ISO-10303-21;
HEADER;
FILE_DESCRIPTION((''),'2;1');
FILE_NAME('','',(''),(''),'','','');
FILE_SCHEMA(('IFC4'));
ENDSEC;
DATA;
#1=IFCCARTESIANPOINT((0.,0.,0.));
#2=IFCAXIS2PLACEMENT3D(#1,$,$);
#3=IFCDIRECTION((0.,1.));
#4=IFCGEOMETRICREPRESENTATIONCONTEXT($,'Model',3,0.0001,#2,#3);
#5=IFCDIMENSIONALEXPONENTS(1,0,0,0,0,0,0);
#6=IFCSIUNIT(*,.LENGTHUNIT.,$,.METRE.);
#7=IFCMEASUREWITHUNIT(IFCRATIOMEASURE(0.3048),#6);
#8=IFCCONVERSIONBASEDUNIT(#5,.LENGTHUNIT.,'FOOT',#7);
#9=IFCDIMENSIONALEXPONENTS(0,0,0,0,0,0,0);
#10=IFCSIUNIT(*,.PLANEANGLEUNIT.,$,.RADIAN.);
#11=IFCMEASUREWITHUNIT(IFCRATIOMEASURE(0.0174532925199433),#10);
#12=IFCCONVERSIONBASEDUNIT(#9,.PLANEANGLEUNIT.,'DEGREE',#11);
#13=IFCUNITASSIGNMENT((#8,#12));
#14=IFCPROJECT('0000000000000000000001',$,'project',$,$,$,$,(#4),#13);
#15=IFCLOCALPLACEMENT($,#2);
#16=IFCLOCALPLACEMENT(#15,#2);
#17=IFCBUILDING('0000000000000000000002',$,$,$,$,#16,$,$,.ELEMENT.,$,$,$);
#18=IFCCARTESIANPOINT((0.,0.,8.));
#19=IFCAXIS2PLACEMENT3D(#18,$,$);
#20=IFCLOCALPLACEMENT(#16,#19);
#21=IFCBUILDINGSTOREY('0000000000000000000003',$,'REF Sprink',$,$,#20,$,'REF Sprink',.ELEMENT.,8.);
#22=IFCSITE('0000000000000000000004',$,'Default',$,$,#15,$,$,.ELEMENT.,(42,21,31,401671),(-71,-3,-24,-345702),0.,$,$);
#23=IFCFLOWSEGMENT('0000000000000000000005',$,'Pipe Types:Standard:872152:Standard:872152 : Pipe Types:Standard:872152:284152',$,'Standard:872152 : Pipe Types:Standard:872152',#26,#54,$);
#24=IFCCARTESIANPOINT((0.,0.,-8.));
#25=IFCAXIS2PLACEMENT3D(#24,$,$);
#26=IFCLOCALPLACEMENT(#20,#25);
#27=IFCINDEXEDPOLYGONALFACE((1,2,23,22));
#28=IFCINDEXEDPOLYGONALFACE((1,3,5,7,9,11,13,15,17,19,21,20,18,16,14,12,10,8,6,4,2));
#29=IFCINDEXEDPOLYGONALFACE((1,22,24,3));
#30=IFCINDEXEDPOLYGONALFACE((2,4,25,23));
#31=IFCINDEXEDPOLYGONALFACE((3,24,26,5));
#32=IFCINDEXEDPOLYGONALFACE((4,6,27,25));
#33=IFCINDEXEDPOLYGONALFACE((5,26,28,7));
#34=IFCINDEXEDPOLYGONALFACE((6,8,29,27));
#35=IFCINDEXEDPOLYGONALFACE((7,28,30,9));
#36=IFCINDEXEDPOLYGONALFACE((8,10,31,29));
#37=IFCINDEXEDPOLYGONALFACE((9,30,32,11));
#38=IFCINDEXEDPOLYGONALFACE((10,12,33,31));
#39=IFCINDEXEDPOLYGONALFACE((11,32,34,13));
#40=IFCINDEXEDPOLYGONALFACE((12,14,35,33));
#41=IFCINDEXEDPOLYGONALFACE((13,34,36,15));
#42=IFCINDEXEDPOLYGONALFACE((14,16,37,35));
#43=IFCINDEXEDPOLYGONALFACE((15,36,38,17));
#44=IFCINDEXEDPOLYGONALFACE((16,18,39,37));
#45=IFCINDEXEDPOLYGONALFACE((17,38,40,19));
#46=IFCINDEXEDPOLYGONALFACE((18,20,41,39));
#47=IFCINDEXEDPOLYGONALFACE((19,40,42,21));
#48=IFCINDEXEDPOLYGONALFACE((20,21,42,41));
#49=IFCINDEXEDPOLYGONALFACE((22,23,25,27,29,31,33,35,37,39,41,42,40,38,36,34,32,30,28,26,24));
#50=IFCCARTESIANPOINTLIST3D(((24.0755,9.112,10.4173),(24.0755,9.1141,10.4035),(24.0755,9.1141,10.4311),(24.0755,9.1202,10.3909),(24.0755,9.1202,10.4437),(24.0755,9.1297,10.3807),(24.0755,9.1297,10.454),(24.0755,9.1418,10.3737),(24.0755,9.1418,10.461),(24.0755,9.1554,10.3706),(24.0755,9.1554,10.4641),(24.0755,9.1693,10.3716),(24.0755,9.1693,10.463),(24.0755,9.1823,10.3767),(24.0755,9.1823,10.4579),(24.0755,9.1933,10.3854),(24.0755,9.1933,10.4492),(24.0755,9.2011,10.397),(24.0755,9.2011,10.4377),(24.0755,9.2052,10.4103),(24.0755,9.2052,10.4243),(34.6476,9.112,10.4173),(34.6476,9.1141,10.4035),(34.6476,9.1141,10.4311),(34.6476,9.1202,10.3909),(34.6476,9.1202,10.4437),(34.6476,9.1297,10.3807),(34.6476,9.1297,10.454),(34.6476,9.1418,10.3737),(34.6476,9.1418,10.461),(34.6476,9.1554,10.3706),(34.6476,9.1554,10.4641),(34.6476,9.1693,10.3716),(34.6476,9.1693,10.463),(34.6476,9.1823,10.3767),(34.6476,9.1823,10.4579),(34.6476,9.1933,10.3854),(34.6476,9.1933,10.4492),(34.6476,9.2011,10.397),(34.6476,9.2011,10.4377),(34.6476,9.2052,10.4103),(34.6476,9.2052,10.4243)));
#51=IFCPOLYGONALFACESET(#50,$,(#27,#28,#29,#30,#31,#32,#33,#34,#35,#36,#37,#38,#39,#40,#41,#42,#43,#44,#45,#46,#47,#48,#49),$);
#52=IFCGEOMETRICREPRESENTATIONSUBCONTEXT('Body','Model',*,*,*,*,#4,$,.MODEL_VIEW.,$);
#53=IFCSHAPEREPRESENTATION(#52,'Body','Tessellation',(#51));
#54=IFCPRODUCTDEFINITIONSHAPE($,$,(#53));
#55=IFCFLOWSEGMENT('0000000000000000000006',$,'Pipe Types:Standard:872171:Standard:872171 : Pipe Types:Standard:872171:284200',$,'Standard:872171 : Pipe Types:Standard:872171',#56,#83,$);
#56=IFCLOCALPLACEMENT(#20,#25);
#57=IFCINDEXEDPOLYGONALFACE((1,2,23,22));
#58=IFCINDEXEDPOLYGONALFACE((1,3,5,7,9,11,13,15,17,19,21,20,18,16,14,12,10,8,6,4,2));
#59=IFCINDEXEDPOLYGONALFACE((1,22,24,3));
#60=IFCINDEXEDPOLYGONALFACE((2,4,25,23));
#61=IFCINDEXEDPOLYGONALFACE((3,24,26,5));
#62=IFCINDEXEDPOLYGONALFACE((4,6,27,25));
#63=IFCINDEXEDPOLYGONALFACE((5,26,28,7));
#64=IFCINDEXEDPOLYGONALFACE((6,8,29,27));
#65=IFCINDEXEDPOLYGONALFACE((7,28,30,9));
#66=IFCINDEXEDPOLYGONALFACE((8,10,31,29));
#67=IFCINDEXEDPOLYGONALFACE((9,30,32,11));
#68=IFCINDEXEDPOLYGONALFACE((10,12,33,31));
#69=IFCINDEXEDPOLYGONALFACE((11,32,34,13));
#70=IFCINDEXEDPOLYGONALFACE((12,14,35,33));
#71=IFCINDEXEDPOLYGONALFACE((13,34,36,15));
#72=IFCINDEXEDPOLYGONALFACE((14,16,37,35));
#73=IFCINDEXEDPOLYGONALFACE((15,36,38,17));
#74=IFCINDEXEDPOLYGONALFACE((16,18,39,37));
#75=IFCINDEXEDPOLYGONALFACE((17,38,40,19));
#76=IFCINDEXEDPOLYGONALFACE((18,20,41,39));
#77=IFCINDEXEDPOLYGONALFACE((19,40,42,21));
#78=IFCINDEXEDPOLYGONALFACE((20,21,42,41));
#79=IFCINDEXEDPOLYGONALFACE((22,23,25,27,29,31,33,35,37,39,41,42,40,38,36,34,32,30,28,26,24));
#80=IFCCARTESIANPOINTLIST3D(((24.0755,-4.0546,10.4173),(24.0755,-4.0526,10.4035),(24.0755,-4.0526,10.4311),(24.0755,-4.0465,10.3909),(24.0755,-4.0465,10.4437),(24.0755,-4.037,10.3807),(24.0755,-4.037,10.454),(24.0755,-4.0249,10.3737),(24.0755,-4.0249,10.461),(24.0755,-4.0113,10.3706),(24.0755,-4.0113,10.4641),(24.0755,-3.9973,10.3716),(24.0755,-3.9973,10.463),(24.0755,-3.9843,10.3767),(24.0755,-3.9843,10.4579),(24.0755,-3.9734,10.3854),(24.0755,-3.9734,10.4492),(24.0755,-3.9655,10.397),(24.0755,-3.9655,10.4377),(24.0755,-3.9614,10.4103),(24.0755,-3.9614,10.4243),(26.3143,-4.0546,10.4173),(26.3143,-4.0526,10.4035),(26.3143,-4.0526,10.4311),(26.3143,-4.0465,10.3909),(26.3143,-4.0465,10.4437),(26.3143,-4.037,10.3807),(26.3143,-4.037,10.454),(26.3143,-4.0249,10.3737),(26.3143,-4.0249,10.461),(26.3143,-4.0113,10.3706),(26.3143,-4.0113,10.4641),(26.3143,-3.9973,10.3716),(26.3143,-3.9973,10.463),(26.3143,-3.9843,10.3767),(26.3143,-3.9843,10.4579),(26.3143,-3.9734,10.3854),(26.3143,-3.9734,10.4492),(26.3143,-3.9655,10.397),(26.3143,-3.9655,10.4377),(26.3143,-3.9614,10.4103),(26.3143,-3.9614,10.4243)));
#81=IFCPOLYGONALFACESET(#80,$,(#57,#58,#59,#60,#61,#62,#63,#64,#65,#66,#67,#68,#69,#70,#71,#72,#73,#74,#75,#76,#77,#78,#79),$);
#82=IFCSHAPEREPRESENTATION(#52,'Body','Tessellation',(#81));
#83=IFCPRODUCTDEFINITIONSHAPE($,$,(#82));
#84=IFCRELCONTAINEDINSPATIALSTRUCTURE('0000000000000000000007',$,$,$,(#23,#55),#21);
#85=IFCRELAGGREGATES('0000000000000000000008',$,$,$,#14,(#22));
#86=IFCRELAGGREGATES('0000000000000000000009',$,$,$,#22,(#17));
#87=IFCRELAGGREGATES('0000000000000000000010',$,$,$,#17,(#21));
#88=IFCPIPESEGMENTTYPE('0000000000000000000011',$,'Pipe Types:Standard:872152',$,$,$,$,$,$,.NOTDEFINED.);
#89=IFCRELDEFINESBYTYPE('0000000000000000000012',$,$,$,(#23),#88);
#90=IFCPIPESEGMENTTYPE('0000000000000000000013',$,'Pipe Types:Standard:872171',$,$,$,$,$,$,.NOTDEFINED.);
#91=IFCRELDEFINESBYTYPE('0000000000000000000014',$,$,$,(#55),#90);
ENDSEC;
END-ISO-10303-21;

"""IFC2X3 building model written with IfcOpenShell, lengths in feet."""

from ifc_helpers import new_model, entity, si_unit, converted_unit, direction, frame, origin, origin_2d_with_axis, place, context, subcontext, project, spatial, circle, extrude, source, transform, mapped, type_object, type_shapes, element, save


model = new_model("IFC2X3")

# Units and contexts
model_context = context("Model", 3, precision=0.0001, world=origin(), true_north=direction((0.0, 1.0)))
body_context = subcontext(model_context, "Body", "Model", "MODEL_VIEW")
ifc_project = project(units=[converted_unit("LENGTHUNIT", "FOOT", entity("IfcRatioMeasure", 0.3048), si_unit("LENGTHUNIT", "METRE"), dimensions=[1, 0, 0, 0, 0, 0, 0]), converted_unit("PLANEANGLEUNIT", "DEGREE", entity("IfcRatioMeasure", 0.0174532925199433), si_unit("PLANEANGLEUNIT", "RADIAN"), dimensions=[0, 0, 0, 0, 0, 0, 0])], contexts=[model_context])

# Site, building, storey
site_placement = place(None, origin())
site = spatial("IfcSite", under=ifc_project, at=site_placement, Name="Default", CompositionType="ELEMENT", RefLatitude=(42, 21, 31, 401671), RefLongitude=(-71, -3, -24, -345702), RefElevation=0.0)
building_placement = place(site_placement, origin())
building = spatial("IfcBuilding", under=site, at=building_placement, CompositionType="ELEMENT")
storey_placement = place(building_placement, frame((0.0, 0.0, 8.0)))
storey = spatial("IfcBuildingStorey", under=building, at=storey_placement, Name="REF Sprink", LongName="REF Sprink", CompositionType="ELEMENT", Elevation=8.0)

# Flow segments
pipe_segment_type_1 = type_object("IfcPipeSegmentType", Name="Pipe Types:Standard:872152", PredefinedType="NOTDEFINED")
shared_shape_1 = source(origin(), body_context, "Body", "SweptSolid", [
    extrude(circle(Radius=0.0469, at=origin_2d_with_axis()), frame((24.0755, 9.1589, 10.4173), z_axis=(1.0, 0.0, 0.0), x_axis=(0.0, -1.0, 0.0)), (0.0, 0.0, 1.0), 10.5722),
])
type_shapes(pipe_segment_type_1, [shared_shape_1])
flow_segment_1_placement = place(storey_placement, frame((0.0, 0.0, -8.0)))
element("IfcFlowSegment", 1, at=flow_segment_1_placement, inside=storey, type_object=pipe_segment_type_1, Name="Pipe Types:Standard:872152:Standard:872152 : Pipe Types:Standard:872152:284152", ObjectType="Standard:872152 : Pipe Types:Standard:872152", context=body_context, shape_type="MappedRepresentation", body=[
    mapped(shared_shape_1, transform((0.0, 0.0, 0.0), scale=1.0)),
])
pipe_segment_type_2 = type_object("IfcPipeSegmentType", Name="Pipe Types:Standard:872171", PredefinedType="NOTDEFINED")
shared_shape_2 = source(origin(), body_context, "Body", "SweptSolid", [
    extrude(circle(Radius=0.0469, at=origin_2d_with_axis()), frame((24.0755, -4.0078, 10.4173), z_axis=(1.0, 0.0, 0.0), x_axis=(0.0, -1.0, 0.0)), (0.0, 0.0, 1.0), 2.2388),
])
type_shapes(pipe_segment_type_2, [shared_shape_2])
flow_segment_2_placement = place(storey_placement, frame((0.0, 0.0, -8.0)))
element("IfcFlowSegment", 2, at=flow_segment_2_placement, inside=storey, type_object=pipe_segment_type_2, Name="Pipe Types:Standard:872171:Standard:872171 : Pipe Types:Standard:872171:284200", ObjectType="Standard:872171 : Pipe Types:Standard:872171", context=body_context, shape_type="MappedRepresentation", body=[
    mapped(shared_shape_2, transform((0.0, 0.0, 0.0), scale=1.0)),
])

save(model, "model.ifc")
